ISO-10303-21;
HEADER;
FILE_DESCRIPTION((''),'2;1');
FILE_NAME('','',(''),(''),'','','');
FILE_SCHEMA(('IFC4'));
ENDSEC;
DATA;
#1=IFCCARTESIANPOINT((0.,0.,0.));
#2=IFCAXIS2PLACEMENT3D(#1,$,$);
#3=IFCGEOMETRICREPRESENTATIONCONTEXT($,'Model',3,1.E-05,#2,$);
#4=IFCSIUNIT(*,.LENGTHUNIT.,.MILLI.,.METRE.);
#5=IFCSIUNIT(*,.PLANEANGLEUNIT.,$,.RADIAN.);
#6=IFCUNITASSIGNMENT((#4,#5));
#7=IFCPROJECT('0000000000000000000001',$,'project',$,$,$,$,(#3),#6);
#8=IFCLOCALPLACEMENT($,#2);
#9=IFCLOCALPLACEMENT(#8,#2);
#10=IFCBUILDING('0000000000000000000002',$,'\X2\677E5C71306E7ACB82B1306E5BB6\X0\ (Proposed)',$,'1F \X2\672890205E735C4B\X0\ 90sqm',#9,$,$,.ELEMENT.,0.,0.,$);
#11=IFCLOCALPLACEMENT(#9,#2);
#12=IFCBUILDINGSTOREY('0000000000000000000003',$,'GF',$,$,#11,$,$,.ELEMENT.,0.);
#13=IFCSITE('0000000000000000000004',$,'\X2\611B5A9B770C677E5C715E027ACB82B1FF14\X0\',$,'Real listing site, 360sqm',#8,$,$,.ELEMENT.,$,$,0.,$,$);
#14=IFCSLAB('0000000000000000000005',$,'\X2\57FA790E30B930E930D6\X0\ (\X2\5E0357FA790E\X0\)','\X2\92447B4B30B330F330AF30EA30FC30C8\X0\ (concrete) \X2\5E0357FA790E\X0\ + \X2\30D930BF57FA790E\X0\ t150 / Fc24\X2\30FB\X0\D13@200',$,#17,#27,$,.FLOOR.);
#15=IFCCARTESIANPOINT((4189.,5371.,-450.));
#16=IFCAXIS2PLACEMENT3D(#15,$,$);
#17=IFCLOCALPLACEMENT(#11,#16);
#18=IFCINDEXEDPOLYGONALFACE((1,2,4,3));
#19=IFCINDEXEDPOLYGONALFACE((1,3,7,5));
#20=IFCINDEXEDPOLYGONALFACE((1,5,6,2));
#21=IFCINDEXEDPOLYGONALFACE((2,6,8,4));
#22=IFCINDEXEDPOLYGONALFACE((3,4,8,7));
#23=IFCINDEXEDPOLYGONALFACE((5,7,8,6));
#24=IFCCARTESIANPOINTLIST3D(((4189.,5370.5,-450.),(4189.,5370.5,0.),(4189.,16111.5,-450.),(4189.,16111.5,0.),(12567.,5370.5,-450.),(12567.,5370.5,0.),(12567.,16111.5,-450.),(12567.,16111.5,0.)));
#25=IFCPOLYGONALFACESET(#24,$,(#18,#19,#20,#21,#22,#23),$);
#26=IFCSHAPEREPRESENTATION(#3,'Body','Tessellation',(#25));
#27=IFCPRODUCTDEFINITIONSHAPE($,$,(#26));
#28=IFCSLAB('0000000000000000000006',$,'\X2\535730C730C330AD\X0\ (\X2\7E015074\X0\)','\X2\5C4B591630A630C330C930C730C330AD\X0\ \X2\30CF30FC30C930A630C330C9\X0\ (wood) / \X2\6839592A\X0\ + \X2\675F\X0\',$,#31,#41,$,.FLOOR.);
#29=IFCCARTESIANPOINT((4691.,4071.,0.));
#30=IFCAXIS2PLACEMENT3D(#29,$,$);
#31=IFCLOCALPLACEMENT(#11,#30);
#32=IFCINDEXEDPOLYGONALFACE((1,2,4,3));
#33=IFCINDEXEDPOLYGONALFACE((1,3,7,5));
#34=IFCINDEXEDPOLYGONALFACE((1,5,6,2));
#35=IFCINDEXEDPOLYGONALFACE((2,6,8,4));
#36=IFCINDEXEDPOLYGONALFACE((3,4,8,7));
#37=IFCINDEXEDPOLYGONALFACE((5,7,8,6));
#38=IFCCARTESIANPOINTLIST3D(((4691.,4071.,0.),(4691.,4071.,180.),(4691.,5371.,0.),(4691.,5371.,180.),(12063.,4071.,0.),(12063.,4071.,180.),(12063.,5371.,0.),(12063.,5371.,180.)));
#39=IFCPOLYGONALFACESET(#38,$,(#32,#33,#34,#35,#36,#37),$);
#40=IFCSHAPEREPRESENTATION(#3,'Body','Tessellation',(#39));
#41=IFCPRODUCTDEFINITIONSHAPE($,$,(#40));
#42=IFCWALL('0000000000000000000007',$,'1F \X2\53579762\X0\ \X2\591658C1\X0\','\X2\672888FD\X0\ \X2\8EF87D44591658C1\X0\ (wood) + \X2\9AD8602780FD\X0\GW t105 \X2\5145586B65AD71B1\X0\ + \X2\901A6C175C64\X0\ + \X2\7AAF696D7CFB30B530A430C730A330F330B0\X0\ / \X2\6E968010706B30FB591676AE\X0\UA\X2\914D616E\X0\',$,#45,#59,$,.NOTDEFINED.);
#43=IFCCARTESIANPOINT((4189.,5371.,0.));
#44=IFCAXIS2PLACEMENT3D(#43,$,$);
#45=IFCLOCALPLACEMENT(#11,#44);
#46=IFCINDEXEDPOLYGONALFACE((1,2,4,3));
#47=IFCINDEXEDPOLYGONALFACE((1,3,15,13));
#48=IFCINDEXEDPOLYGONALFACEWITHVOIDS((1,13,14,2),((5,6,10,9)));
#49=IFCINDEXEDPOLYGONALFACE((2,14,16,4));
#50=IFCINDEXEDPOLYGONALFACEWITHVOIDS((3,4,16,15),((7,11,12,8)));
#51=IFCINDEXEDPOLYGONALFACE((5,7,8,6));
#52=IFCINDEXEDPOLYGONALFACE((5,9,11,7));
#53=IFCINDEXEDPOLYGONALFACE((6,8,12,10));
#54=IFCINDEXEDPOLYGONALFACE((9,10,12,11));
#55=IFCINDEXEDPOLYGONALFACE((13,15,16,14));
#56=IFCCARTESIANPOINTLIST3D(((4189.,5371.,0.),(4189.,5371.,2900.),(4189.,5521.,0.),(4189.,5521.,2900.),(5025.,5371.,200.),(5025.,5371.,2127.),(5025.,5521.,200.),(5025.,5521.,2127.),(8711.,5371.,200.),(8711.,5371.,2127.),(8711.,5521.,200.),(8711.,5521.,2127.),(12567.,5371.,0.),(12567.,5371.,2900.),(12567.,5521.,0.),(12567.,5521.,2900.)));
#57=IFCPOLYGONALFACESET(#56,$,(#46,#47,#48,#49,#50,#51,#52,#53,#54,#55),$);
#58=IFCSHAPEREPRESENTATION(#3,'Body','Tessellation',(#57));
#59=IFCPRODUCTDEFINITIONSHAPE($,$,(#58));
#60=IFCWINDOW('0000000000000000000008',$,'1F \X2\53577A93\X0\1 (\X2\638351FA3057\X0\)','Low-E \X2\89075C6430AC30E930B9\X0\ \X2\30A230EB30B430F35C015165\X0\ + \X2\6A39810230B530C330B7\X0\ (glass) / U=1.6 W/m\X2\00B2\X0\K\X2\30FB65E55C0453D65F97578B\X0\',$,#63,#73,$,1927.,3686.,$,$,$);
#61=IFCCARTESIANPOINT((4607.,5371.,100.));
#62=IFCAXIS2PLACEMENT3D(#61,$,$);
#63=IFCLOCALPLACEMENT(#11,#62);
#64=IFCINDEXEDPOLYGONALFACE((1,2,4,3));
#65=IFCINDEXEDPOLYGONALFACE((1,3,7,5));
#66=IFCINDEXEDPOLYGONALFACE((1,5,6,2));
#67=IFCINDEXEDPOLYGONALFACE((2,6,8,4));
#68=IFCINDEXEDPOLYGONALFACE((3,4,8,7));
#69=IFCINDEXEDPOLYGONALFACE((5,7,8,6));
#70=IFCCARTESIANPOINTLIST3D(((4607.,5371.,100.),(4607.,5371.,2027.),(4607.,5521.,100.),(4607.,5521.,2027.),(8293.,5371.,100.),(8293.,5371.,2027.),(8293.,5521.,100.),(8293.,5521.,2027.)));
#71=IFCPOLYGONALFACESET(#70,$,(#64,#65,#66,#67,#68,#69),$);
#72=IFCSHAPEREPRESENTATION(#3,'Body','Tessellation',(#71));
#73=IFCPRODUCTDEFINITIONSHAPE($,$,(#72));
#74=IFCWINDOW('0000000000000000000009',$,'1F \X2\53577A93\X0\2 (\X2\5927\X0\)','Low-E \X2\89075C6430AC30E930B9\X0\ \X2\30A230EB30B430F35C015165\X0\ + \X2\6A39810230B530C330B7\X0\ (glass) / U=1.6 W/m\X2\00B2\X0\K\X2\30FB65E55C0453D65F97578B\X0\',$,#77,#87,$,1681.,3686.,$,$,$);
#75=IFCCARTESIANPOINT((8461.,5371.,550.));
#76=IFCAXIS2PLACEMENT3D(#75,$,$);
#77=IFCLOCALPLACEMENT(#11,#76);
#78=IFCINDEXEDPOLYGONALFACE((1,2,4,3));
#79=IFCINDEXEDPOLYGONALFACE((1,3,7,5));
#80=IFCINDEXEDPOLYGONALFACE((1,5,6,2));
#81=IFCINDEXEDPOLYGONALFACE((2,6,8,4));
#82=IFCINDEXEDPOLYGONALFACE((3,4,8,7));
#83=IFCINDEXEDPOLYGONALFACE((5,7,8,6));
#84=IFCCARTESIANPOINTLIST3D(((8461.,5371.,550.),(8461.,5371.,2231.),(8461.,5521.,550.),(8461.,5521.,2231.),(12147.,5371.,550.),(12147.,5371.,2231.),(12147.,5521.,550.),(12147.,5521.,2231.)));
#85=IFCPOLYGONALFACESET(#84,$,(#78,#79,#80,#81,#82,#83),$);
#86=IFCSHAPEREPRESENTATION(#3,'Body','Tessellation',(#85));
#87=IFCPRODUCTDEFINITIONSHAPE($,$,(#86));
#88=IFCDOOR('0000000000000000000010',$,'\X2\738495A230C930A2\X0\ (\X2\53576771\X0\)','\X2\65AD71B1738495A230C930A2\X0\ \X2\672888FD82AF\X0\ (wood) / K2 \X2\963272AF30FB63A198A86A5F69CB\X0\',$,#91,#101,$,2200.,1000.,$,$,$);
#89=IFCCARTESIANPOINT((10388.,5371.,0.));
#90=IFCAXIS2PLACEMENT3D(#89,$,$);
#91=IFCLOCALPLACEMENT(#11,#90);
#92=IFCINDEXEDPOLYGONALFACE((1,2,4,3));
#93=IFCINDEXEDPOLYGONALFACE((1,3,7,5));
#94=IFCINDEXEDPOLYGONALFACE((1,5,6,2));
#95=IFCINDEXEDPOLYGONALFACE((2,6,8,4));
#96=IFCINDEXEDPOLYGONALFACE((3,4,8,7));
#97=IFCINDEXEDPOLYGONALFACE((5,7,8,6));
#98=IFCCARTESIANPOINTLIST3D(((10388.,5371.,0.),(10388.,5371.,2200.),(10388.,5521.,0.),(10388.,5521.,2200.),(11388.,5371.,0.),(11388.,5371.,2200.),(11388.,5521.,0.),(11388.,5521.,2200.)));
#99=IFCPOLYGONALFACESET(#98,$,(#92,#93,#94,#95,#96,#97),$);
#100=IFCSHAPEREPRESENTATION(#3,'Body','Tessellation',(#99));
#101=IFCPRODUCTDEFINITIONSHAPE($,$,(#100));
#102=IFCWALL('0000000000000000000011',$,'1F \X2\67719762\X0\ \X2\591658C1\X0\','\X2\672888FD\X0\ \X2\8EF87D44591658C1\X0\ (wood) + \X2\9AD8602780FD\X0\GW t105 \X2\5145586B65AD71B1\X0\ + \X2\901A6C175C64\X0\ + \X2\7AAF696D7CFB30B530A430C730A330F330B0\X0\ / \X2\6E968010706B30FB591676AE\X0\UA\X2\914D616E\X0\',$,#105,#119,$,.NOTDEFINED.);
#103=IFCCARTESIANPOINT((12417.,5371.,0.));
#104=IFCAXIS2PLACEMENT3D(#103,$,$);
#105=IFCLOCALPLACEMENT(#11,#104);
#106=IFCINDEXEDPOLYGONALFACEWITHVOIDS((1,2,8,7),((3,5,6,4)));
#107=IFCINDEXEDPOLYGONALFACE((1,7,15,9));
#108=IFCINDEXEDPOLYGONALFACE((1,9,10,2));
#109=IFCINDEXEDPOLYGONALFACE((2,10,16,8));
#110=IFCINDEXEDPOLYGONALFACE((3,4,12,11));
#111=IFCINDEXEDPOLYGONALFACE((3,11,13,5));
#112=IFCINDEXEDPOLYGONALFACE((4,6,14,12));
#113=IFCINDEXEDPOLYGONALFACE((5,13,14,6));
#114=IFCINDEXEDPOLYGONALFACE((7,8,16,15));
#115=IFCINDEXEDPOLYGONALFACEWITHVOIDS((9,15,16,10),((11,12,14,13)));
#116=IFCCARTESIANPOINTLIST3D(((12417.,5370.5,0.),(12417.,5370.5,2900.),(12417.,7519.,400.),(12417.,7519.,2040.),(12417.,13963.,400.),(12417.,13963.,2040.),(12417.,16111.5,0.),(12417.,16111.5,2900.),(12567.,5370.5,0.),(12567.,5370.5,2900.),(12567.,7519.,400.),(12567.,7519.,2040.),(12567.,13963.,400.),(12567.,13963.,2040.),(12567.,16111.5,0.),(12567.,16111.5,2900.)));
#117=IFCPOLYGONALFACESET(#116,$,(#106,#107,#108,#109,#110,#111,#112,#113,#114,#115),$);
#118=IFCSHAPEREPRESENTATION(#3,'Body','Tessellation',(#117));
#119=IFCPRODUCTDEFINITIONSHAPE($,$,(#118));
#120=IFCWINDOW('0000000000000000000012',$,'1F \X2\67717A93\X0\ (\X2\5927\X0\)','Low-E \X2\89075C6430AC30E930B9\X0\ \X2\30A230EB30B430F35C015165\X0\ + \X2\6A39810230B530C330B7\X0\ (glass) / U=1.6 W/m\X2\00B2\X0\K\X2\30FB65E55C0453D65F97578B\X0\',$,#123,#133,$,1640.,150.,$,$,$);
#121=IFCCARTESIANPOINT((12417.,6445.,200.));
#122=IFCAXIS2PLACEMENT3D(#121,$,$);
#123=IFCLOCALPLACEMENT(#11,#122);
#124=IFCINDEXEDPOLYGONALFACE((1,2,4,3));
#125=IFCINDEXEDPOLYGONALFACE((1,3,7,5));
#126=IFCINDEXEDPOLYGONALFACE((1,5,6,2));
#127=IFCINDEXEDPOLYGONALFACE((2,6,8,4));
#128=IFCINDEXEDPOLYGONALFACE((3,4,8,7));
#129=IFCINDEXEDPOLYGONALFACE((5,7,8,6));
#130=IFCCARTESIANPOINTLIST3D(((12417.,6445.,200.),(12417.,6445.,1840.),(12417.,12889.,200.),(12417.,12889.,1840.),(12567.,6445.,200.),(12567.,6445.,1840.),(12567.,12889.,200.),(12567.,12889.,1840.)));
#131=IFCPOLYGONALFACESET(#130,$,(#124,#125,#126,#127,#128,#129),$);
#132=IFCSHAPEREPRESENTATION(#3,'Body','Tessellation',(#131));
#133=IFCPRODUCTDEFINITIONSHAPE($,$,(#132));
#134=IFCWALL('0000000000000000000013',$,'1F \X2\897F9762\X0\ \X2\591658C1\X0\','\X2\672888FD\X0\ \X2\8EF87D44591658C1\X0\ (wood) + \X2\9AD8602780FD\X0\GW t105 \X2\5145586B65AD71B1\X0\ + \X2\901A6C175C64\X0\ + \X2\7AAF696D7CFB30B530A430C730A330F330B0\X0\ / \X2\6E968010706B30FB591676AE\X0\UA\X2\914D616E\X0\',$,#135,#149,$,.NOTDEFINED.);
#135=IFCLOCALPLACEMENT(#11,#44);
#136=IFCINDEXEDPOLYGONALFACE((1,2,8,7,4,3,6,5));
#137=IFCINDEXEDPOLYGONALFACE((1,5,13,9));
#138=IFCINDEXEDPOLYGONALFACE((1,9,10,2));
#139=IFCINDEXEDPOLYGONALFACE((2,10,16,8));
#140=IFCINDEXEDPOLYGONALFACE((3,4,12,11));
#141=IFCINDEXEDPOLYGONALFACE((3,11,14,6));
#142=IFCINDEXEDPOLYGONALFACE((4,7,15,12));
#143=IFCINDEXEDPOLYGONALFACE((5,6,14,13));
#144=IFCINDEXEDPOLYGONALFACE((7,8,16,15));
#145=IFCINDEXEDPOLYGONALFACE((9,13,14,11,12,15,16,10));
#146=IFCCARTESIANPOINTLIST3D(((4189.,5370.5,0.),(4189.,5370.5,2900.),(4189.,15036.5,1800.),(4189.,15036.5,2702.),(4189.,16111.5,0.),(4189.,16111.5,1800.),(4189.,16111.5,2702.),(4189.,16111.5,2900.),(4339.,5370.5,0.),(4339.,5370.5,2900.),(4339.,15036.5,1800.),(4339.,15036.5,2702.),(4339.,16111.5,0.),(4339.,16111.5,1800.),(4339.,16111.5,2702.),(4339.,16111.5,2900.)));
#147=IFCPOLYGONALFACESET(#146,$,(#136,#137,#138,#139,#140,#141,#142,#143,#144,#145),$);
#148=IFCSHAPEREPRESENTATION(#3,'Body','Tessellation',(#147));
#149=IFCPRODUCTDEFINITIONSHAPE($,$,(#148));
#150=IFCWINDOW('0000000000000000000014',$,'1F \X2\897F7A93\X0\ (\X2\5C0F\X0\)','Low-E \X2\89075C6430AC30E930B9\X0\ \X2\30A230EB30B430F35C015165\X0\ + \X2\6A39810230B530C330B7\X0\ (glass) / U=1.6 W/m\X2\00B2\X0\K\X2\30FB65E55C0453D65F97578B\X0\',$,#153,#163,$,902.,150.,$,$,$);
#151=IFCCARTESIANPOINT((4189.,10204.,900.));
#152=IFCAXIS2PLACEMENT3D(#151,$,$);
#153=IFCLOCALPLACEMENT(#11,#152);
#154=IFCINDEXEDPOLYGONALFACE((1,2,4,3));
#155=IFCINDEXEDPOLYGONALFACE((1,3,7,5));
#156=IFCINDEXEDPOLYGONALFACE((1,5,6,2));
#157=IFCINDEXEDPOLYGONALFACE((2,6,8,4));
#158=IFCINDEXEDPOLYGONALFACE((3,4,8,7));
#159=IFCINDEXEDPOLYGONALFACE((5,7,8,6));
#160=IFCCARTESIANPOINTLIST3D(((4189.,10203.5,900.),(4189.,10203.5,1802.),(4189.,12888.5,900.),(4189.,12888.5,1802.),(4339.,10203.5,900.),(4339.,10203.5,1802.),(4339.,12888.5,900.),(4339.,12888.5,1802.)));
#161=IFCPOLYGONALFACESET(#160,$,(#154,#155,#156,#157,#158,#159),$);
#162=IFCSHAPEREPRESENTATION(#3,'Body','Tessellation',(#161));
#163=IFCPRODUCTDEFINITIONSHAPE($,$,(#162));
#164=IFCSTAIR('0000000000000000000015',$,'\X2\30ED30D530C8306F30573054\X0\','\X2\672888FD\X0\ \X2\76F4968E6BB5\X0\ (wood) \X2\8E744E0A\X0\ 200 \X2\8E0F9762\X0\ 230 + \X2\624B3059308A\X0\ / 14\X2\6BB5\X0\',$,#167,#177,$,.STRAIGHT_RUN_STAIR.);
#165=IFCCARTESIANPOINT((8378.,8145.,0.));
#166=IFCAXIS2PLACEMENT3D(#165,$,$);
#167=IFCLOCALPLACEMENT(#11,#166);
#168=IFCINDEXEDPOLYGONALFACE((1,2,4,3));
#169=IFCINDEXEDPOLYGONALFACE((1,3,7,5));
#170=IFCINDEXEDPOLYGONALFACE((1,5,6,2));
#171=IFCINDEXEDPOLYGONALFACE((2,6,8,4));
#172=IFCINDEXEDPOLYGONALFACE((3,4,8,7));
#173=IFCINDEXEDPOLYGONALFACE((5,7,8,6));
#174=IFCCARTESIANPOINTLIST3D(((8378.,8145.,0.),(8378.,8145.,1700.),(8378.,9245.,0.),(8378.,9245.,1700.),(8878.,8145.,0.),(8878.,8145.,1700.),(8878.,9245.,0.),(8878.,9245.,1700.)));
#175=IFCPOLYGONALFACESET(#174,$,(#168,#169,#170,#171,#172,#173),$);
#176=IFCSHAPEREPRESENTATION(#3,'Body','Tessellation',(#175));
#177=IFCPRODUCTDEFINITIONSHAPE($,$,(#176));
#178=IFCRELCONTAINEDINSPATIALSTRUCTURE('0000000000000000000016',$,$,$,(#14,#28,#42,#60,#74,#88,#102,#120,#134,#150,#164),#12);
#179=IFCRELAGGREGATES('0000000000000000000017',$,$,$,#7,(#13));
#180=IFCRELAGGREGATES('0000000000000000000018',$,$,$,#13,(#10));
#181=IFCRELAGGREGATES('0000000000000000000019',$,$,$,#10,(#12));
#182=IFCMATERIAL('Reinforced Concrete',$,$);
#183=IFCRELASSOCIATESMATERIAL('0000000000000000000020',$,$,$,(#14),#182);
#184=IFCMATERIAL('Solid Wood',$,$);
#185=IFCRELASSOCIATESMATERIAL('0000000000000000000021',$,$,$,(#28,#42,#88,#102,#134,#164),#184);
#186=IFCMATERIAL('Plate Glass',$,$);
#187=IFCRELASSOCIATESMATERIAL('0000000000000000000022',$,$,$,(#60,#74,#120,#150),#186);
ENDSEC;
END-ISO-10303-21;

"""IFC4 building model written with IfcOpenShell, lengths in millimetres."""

from ifc_helpers import new_model, si_unit, frame, frame_2d, origin, place, context, project, spatial, rectangle, extrude, material, element, fill, save


model = new_model("IFC4")

# Units and contexts
model_context = context("Model", 3, precision=1e-05, world=origin())
ifc_project = project(units=[si_unit("LENGTHUNIT", "METRE", prefix="MILLI"), si_unit("PLANEANGLEUNIT", "RADIAN")], contexts=[model_context])

# Site, building, storey
site_placement = place(None, origin())
site = spatial("IfcSite", under=ifc_project, at=site_placement, Name="愛媛県松山市立花４", ObjectType="Real listing site, 360sqm", CompositionType="ELEMENT", RefElevation=0.0)
building_placement = place(site_placement, origin())
building = spatial("IfcBuilding", under=site, at=building_placement, Name="松山の立花の家 (Proposed)", ObjectType="1F 木造平屋 90sqm", CompositionType="ELEMENT", ElevationOfRefHeight=0.0, ElevationOfTerrain=0.0)
storey_placement = place(building_placement, origin())
storey = spatial("IfcBuildingStorey", under=building, at=storey_placement, Name="GF", CompositionType="ELEMENT", Elevation=0.0)

# Slabs
ifc_material_1 = material(Name="Reinforced Concrete")
slab_1_placement = place(storey_placement, frame((4189.0, 5371.0, -450.0)))
element("IfcSlab", 1, at=slab_1_placement, inside=storey, material=ifc_material_1, Name="基礎スラブ (布基礎)", Description="鉄筋コンクリート (concrete) 布基礎 + ベタ基礎 t150 / Fc24・D13@200", PredefinedType="FLOOR", context=model_context, shape_type="SweptSolid", body=[
    extrude(rectangle(XDim=8378.0, YDim=10741.0, at=frame_2d((4189.0, 5370.0))), frame((4189.0, 5371.0, -450.0)), (0.0, 0.0, 1.0), 450.0),
])
ifc_material_2 = material(Name="Solid Wood")
slab_2_placement = place(storey_placement, frame((4691.0, 4071.0, 0.0)))
element("IfcSlab", 2, at=slab_2_placement, inside=storey, material=ifc_material_2, Name="南デッキ (縁側)", Description="屋外ウッドデッキ ハードウッド (wood) / 根太 + 束", PredefinedType="FLOOR", context=model_context, shape_type="SweptSolid", body=[
    extrude(rectangle(XDim=7372.0, YDim=1300.0, at=frame_2d((3686.0, 650.0))), frame((4691.0, 4071.0, 0.0)), (0.0, 0.0, 1.0), 180.0),
])

# Wall, openings, windows, door
wall_1_placement = place(storey_placement, frame((4189.0, 5371.0, 0.0)))
wall_1 = element("IfcWall", 3, at=wall_1_placement, inside=storey, material=ifc_material_2, Name="1F 南面 外壁", Description="木製 軸組外壁 (wood) + 高性能GW t105 充填断熱 + 通気層 + 窯業系サイディング / 準耐火・外皮UA配慮", PredefinedType="NOTDEFINED", context=model_context, shape_type="SweptSolid", body=[
    extrude(rectangle(XDim=8378.0, YDim=150.0, at=frame_2d((4189.0, 75.0))), frame((4189.0, 5371.0, 0.0)), (0.0, 0.0, 1.0), 2900.0),
])
opening_1_placement = place(storey_placement, frame((4607.0, 5371.0, 100.0)))
opening_1 = element("IfcOpeningElement", 4, at=opening_1_placement, cuts=wall_1, PredefinedType="NOTDEFINED", context=model_context, shape_type="SweptSolid", body=[
    extrude(rectangle(XDim=3686.0, YDim=150.0, at=frame_2d((1843.0, 75.0))), frame((4607.0, 5371.0, 100.0)), (0.0, 0.0, 1.0), 1927.0),
])
opening_2_placement = place(storey_placement, frame((8461.0, 5371.0, 550.0)))
opening_2 = element("IfcOpeningElement", 5, at=opening_2_placement, cuts=wall_1, PredefinedType="NOTDEFINED", context=model_context, shape_type="SweptSolid", body=[
    extrude(rectangle(XDim=3686.0, YDim=150.0, at=frame_2d((1843.0, 75.0))), frame((8461.0, 5371.0, 550.0)), (0.0, 0.0, 1.0), 1681.0),
])
opening_3_placement = place(storey_placement, frame((10388.0, 5371.0, 0.0)))
opening_3 = element("IfcOpeningElement", 6, at=opening_3_placement, cuts=wall_1, PredefinedType="NOTDEFINED", context=model_context, shape_type="SweptSolid", body=[
    extrude(rectangle(XDim=1000.0, YDim=150.0, at=frame_2d((500.0, 75.0))), frame((10388.0, 5371.0, 0.0)), (0.0, 0.0, 1.0), 2200.0),
])
ifc_material_3 = material(Name="Plate Glass")
window_1_placement = place(storey_placement, frame((4607.0, 5371.0, 100.0)))
window_1 = element("IfcWindow", 7, at=window_1_placement, inside=storey, material=ifc_material_3, Name="1F 南窓1 (掃出し)", Description="Low-E 複層ガラス アルゴン封入 + 樹脂サッシ (glass) / U=1.6 W/m²K・日射取得型", OverallHeight=1927.0, OverallWidth=3686.0, context=model_context, shape_type="SweptSolid", body=[
    extrude(rectangle(XDim=3686.0, YDim=150.0, at=frame_2d((1843.0, 75.0))), frame((4607.0, 5371.0, 100.0)), (0.0, 0.0, 1.0), 1927.0),
])
fill(opening_1, window_1)
window_2_placement = place(storey_placement, frame((8461.0, 5371.0, 550.0)))
window_2 = element("IfcWindow", 8, at=window_2_placement, inside=storey, material=ifc_material_3, Name="1F 南窓2 (大)", Description="Low-E 複層ガラス アルゴン封入 + 樹脂サッシ (glass) / U=1.6 W/m²K・日射取得型", OverallHeight=1681.0, OverallWidth=3686.0, context=model_context, shape_type="SweptSolid", body=[
    extrude(rectangle(XDim=3686.0, YDim=150.0, at=frame_2d((1843.0, 75.0))), frame((8461.0, 5371.0, 550.0)), (0.0, 0.0, 1.0), 1681.0),
])
fill(opening_2, window_2)
door_placement = place(storey_placement, frame((10388.0, 5371.0, 0.0)))
door = element("IfcDoor", 9, at=door_placement, inside=storey, material=ifc_material_2, Name="玄関ドア (南東)", Description="断熱玄関ドア 木製芯 (wood) / K2 防犯・採風機構", OverallHeight=2200.0, OverallWidth=1000.0, context=model_context, shape_type="SweptSolid", body=[
    extrude(rectangle(XDim=1000.0, YDim=150.0, at=frame_2d((500.0, 75.0))), frame((10388.0, 5371.0, 0.0)), (0.0, 0.0, 1.0), 2200.0),
])
fill(opening_3, door)

# Walls, openings, windows
wall_2_placement = place(storey_placement, frame((12417.0, 5371.0, 0.0)))
wall_2 = element("IfcWall", 10, at=wall_2_placement, inside=storey, material=ifc_material_2, Name="1F 東面 外壁", Description="木製 軸組外壁 (wood) + 高性能GW t105 充填断熱 + 通気層 + 窯業系サイディング / 準耐火・外皮UA配慮", PredefinedType="NOTDEFINED", context=model_context, shape_type="SweptSolid", body=[
    extrude(rectangle(XDim=150.0, YDim=10741.0, at=frame_2d((75.0, 5370.0))), frame((12417.0, 5371.0, 0.0)), (0.0, 0.0, 1.0), 2900.0),
])
opening_4_placement = place(storey_placement, frame((12417.0, 6445.0, 200.0)))
opening_4 = element("IfcOpeningElement", 11, at=opening_4_placement, cuts=wall_2, PredefinedType="NOTDEFINED", context=model_context, shape_type="SweptSolid", body=[
    extrude(rectangle(XDim=150.0, YDim=6444.0, at=frame_2d((75.0, 3222.0))), frame((12417.0, 6445.0, 200.0)), (0.0, 0.0, 1.0), 1640.0),
])
window_3_placement = place(storey_placement, frame((12417.0, 6445.0, 200.0)))
window_3 = element("IfcWindow", 12, at=window_3_placement, inside=storey, material=ifc_material_3, Name="1F 東窓 (大)", Description="Low-E 複層ガラス アルゴン封入 + 樹脂サッシ (glass) / U=1.6 W/m²K・日射取得型", OverallHeight=1640.0, OverallWidth=150.0, context=model_context, shape_type="SweptSolid", body=[
    extrude(rectangle(XDim=150.0, YDim=6444.0, at=frame_2d((75.0, 3222.0))), frame((12417.0, 6445.0, 200.0)), (0.0, 0.0, 1.0), 1640.0),
])
fill(opening_4, window_3)
wall_3_placement = place(storey_placement, frame((4189.0, 5371.0, 0.0)))
wall_3 = element("IfcWall", 13, at=wall_3_placement, inside=storey, material=ifc_material_2, Name="1F 西面 外壁", Description="木製 軸組外壁 (wood) + 高性能GW t105 充填断熱 + 通気層 + 窯業系サイディング / 準耐火・外皮UA配慮", PredefinedType="NOTDEFINED", context=model_context, shape_type="SweptSolid", body=[
    extrude(rectangle(XDim=150.0, YDim=10741.0, at=frame_2d((75.0, 5370.0))), frame((4189.0, 5371.0, 0.0)), (0.0, 0.0, 1.0), 2900.0),
])
opening_5_placement = place(storey_placement, frame((4189.0, 10204.0, 900.0)))
opening_5 = element("IfcOpeningElement", 14, at=opening_5_placement, cuts=wall_3, PredefinedType="NOTDEFINED", context=model_context, shape_type="SweptSolid", body=[
    extrude(rectangle(XDim=150.0, YDim=2685.0, at=frame_2d((75.0, 1342.0))), frame((4189.0, 10204.0, 900.0)), (0.0, 0.0, 1.0), 902.0),
])
window_4_placement = place(storey_placement, frame((4189.0, 10204.0, 900.0)))
window_4 = element("IfcWindow", 15, at=window_4_placement, inside=storey, material=ifc_material_3, Name="1F 西窓 (小)", Description="Low-E 複層ガラス アルゴン封入 + 樹脂サッシ (glass) / U=1.6 W/m²K・日射取得型", OverallHeight=902.0, OverallWidth=150.0, context=model_context, shape_type="SweptSolid", body=[
    extrude(rectangle(XDim=150.0, YDim=2685.0, at=frame_2d((75.0, 1342.0))), frame((4189.0, 10204.0, 900.0)), (0.0, 0.0, 1.0), 902.0),
])
fill(opening_5, window_4)

# Stair
stair_placement = place(storey_placement, frame((8378.0, 8145.0, 0.0)))
element("IfcStair", 16, at=stair_placement, inside=storey, material=ifc_material_2, Name="ロフトはしご", Description="木製 直階段 (wood) 蹴上 200 踏面 230 + 手すり / 14段", PredefinedType="STRAIGHT_RUN_STAIR", context=model_context, shape_type="SweptSolid", body=[
    extrude(rectangle(XDim=500.0, YDim=1100.0, at=frame_2d((250.0, 550.0))), frame((8378.0, 8145.0, 0.0)), (0.0, 0.0, 1.0), 1700.0),
])

save(model, "model.ifc")
